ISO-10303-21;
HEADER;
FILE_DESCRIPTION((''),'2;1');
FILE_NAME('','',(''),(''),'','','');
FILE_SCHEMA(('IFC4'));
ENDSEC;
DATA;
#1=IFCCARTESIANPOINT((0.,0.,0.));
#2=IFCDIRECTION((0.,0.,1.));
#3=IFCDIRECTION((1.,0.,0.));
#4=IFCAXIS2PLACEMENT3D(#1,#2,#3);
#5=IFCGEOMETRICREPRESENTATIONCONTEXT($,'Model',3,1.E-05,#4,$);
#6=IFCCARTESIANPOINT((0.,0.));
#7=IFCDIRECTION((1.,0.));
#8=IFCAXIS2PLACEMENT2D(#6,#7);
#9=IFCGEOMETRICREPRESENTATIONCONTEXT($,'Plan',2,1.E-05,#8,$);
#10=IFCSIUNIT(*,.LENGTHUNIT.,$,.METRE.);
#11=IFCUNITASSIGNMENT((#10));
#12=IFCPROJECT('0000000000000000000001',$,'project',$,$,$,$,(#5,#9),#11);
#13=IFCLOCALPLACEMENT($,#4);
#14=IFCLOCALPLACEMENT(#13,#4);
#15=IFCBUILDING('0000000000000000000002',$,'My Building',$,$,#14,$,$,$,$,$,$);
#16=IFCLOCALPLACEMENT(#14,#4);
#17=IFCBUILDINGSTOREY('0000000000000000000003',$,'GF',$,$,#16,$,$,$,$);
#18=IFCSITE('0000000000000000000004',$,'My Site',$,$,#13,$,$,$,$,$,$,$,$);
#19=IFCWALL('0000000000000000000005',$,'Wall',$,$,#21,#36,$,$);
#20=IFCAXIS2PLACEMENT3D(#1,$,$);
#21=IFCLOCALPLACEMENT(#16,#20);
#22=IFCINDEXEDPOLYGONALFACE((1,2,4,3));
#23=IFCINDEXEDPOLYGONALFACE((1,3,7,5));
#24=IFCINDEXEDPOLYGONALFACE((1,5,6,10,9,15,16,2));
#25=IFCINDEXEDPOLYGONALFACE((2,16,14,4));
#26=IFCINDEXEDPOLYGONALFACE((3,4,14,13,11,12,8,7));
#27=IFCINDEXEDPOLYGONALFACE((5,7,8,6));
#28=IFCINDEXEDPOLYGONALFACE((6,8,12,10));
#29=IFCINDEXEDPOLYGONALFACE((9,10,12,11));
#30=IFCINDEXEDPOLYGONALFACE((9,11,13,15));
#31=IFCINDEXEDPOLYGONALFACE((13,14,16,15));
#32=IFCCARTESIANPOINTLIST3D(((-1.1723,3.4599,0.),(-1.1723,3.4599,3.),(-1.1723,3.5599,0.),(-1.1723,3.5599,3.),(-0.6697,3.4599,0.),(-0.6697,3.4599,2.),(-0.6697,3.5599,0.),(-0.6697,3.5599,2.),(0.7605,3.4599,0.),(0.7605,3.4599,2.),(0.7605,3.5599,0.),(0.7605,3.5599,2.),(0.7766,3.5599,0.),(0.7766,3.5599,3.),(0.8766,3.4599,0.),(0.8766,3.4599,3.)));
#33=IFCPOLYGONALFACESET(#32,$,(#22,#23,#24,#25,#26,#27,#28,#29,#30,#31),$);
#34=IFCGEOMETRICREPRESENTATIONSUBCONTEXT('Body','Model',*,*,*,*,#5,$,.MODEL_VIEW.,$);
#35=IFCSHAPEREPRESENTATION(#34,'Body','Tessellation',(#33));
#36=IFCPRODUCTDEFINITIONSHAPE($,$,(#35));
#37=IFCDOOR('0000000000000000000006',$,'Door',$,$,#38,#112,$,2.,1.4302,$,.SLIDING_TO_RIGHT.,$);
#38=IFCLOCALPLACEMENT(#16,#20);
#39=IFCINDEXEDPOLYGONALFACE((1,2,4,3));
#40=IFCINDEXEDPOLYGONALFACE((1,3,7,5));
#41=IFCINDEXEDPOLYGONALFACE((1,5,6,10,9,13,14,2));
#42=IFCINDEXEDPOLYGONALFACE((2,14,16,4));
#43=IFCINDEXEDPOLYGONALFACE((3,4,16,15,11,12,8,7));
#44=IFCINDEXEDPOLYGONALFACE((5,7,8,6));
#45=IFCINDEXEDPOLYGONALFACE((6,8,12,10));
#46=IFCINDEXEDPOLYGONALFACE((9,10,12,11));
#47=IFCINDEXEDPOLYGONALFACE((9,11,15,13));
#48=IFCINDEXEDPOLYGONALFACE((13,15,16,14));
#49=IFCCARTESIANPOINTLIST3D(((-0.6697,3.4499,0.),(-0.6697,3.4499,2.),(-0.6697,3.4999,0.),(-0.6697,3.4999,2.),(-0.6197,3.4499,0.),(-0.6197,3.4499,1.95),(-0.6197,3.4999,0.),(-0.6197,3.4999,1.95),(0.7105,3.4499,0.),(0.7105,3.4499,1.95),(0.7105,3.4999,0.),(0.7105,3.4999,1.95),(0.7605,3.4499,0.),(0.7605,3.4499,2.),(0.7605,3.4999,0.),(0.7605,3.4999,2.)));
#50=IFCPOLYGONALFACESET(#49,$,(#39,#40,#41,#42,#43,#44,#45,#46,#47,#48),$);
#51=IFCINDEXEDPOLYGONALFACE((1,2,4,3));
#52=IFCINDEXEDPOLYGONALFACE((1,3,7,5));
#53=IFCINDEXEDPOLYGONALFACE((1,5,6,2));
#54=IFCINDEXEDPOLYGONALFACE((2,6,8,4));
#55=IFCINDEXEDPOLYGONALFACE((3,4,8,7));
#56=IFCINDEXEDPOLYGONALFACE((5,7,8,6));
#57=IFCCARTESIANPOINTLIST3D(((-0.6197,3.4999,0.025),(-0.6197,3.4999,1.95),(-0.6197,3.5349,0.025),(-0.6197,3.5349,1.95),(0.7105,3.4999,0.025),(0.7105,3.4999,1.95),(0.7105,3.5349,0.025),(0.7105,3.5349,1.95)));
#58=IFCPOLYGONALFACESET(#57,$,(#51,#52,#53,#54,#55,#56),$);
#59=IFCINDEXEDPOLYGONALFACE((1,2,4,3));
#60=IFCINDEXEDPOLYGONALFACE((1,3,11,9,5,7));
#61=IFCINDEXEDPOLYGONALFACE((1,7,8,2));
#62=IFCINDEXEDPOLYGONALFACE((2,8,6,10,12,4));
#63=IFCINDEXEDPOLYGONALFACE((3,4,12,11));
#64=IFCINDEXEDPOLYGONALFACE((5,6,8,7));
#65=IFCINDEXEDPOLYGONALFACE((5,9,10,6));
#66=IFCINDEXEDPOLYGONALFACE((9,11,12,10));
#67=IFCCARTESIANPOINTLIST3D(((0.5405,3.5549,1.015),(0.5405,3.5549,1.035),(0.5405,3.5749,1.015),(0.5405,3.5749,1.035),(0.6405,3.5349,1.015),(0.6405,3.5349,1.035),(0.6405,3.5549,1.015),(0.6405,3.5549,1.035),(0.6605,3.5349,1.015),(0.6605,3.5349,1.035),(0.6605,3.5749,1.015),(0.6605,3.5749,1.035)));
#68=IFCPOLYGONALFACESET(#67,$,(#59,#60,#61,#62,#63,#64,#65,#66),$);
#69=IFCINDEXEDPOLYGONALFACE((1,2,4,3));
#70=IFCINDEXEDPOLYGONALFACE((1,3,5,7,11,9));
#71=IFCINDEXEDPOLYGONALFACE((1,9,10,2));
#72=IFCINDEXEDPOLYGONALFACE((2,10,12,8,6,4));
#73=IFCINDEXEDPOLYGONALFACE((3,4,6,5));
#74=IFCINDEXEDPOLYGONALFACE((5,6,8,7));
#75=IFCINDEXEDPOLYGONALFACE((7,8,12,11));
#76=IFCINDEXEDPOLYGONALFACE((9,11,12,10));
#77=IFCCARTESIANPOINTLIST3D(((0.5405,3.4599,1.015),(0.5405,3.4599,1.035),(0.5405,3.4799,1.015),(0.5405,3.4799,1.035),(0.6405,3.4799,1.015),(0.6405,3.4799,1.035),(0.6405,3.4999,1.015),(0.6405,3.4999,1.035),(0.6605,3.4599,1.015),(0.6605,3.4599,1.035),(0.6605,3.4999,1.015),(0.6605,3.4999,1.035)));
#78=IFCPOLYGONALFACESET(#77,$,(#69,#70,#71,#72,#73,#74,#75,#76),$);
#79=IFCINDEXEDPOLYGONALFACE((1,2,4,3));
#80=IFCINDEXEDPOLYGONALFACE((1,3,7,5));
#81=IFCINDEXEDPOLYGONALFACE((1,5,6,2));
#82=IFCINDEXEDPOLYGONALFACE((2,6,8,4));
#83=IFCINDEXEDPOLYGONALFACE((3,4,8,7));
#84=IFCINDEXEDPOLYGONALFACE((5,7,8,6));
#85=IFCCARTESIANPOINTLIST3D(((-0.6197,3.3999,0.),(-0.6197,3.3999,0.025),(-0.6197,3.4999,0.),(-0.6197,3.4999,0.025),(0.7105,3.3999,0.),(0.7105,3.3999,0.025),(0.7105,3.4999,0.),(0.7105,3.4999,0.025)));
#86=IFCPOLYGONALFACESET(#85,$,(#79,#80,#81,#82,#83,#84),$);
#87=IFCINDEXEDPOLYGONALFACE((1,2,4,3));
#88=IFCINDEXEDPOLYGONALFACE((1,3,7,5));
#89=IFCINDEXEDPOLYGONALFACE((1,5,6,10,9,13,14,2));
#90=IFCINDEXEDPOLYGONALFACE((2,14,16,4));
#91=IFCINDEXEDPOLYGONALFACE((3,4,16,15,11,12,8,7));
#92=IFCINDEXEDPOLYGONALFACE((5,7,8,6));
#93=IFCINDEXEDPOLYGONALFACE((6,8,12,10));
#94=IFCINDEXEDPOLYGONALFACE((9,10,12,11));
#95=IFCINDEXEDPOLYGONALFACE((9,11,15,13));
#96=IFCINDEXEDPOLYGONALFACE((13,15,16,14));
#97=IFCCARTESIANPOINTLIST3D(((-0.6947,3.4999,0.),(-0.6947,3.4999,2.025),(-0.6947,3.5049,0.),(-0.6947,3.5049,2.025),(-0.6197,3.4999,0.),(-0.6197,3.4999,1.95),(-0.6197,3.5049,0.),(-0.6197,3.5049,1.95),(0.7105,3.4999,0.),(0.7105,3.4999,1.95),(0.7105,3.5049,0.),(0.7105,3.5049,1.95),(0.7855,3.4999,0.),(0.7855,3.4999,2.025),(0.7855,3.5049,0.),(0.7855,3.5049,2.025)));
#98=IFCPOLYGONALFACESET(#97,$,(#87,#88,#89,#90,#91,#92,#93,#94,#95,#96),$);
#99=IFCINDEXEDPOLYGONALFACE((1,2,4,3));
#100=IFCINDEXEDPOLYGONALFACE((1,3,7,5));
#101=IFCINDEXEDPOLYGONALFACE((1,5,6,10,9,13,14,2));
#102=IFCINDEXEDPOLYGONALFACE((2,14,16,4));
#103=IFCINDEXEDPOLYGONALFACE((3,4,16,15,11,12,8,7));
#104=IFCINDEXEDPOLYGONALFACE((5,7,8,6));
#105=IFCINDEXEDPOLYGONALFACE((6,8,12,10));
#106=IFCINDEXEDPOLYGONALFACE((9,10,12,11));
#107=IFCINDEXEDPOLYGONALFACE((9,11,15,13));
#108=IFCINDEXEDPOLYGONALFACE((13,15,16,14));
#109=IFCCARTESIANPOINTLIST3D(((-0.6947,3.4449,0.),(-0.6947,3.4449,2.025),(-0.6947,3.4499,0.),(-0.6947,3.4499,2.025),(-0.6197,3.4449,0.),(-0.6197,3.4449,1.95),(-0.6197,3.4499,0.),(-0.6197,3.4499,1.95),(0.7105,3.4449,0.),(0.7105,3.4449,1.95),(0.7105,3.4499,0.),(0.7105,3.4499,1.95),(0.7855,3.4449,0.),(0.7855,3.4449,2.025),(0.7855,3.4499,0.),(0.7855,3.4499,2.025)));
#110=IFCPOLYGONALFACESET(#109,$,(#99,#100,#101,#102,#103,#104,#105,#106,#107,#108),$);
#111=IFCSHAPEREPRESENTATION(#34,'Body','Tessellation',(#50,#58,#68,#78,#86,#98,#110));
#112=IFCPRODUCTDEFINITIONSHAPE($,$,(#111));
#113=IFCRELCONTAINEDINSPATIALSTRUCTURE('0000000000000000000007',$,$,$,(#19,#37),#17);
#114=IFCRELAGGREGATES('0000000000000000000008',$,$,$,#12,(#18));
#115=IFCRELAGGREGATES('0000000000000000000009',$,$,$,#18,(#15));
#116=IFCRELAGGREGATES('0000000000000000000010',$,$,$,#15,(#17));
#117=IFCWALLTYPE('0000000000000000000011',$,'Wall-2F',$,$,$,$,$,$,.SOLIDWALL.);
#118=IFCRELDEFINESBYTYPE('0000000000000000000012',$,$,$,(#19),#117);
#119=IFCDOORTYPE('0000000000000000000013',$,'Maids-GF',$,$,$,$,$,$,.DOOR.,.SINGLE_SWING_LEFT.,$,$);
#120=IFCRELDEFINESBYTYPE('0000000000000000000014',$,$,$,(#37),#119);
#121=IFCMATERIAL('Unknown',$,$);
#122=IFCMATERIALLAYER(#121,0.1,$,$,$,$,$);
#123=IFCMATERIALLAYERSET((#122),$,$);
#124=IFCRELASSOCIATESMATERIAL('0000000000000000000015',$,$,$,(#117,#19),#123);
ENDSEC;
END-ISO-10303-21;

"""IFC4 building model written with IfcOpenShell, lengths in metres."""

from ifc_helpers import new_model, entity, si_unit, frame, origin_with_axes, origin_2d_with_axis, place, context, subcontext, project, spatial, line, indexed_curve, outline, extrude, shape, source, transform, mapped, material, layer, layer_set, layer_usage, type_object, type_shapes, element, fill, save


model = new_model("IFC4")

# Units and contexts
model_context = context("Model", 3, precision=1e-05, world=origin_with_axes())
plan_context = context("Plan", 2, precision=1e-05, world=origin_2d_with_axis())
body_context_1 = subcontext(model_context, "Body", "Model", "MODEL_VIEW")
body_context_2 = subcontext(plan_context, "Body", "Plan", "PLAN_VIEW")
ifc_project = project(units=[si_unit("LENGTHUNIT", "METRE")], contexts=[model_context, plan_context])

# Site, building, storey
site_placement = place(None, origin_with_axes())
site = spatial("IfcSite", under=ifc_project, at=site_placement, Name="My Site")
building_placement = place(site_placement, origin_with_axes())
building = spatial("IfcBuilding", under=site, at=building_placement, Name="My Building")
storey_placement = place(building_placement, origin_with_axes())
storey = spatial("IfcBuildingStorey", under=building, at=storey_placement, Name="GF")

# Shared definitions
ifc_material_1 = material(Name="Unknown")

# Shared definitions
ifc_layer_1 = layer(ifc_material_1, 0.1)
ifc_layer_set_1 = layer_set([ifc_layer_1])
wall_type = type_object("IfcWallType", Name="Wall-2F", PredefinedType="SOLIDWALL", material=ifc_layer_set_1)

# Wall, opening, door
ifc_layer_usage_1 = layer_usage(ifc_layer_set_1, "AXIS2", "POSITIVE", 0.0)
wall_1_placement = place(storey_placement, frame((0.7766, 3.5599, 0.0), z_axis=(0.0, 0.0, 1.0), x_axis=(-1.0, 0.0, 0.0)))
wall_1 = element("IfcWall", 1, at=wall_1_placement, inside=storey, type_object=wall_type, material=ifc_layer_usage_1, Name="Wall", context=body_context_1, shape_type="SweptSolid", body=[
    extrude(outline(indexed_curve([(0.0, 0.0), (-0.1, 0.1), (1.9489, 0.1), (1.9489, 0.0)], segments=[line(1, 2, 3, 4, 1)])), origin_with_axes(), (0.0, 0.0, 1.0), 3.0),
])
shared_shape_1 = source(origin_with_axes(), body_context_1, "Body", "SweptSolid", [
    extrude(outline(indexed_curve([(0.0, 0.0), (1.4302, 0.0), (1.4302, 2.0), (0.0, 2.0)], segments=[line(1, 2, 3, 4, 1)])), frame((0.0, -0.6, 0.0), z_axis=(0.0, -1.0, 0.0), x_axis=(1.0, 0.0, 0.0)), (0.0, 0.0, -1.0), 1.2),
])
opening_1_placement = place(wall_1_placement, frame((0.0161, 0.06, 0.0), z_axis=(0.0, 0.0, 1.0), x_axis=(1.0, -0.000002, 0.0)))
opening_1 = element("IfcOpeningElement", 2, at=opening_1_placement, cuts=wall_1, PredefinedType="OPENING", context=body_context_1, shape_type="MappedRepresentation", body=[
    mapped(shared_shape_1, transform((0.0, 0.0, 0.0), x_axis=(1.0, 0.0, 0.0), y_axis=(0.0, 1.0, 0.0), z_axis=(0.0, 0.0, 1.0), scale=1.0)),
])
door_type_1 = type_object("IfcDoorType", Name="Maids-GF", OperationType="SINGLE_SWING_LEFT", PredefinedType="DOOR")
shared_shape_2 = source(origin_with_axes(), body_context_1, "Body", "SweptSolid", [
    extrude(outline(indexed_curve([(0.0, 0.0), (0.0, 2.0), (1.4302, 2.0), (1.4302, 0.0), (1.3802, 0.0), (1.3802, 1.95), (0.05, 1.95), (0.05, 0.0)], segments=[line(1, 2, 3, 4, 5, 6, 7, 8, 1)])), frame((0.0, 0.0, 0.0), z_axis=(0.0, -1.0, 0.0), x_axis=(1.0, 0.0, 0.0)), (0.0, 0.0, -1.0), 0.05),
    extrude(outline(indexed_curve([(0.0, 0.0), (1.3302, 0.0), (1.3302, 0.035), (0.0, 0.035)], segments=[line(1, 2, 3, 4, 1)])), frame((0.05, -0.035, 0.025), z_axis=(0.0, 0.0, 1.0), x_axis=(1.0, 0.0, 0.0)), (0.0, 0.0, 1.0), 1.925),
    extrude(outline(indexed_curve([(0.0, 0.0), (0.0, -0.04), (0.12, -0.04), (0.12, -0.02), (0.02, -0.02), (0.02, 0.0)], segments=[line(1, 2, 3, 4, 5, 6, 1)])), frame((0.1, -0.035, 1.015), z_axis=(0.0, 0.0, 1.0), x_axis=(1.0, 0.0, 0.0)), (0.0, 0.0, 1.0), 0.02),
    extrude(outline(indexed_curve([(0.0, 0.0), (0.0, 0.04), (0.12, 0.04), (0.12, 0.02), (0.02, 0.02), (0.02, 0.0)], segments=[line(1, 2, 3, 4, 5, 6, 1)])), frame((0.1, 0.0, 1.015), z_axis=(0.0, 0.0, 1.0), x_axis=(1.0, 0.0, 0.0)), (0.0, 0.0, 1.0), 0.02),
    extrude(outline(indexed_curve([(0.0, 0.0), (1.3302, 0.0), (1.3302, 0.1), (0.0, 0.1)], segments=[line(1, 2, 3, 4, 1)])), frame((0.05, 0.0, 0.0), z_axis=(0.0, 0.0, 1.0), x_axis=(1.0, 0.0, 0.0)), (0.0, 0.0, 1.0), 0.025),
    extrude(outline(indexed_curve([(0.0, 0.0), (0.0, 2.025), (1.4802, 2.025), (1.4802, 0.0), (1.4052, 0.0), (1.4052, 1.95), (0.075, 1.95), (0.075, 0.0)], segments=[line(1, 2, 3, 4, 5, 6, 7, 8, 1)])), frame((-0.025, -0.005, 0.0), z_axis=(0.0, -1.0, 0.0), x_axis=(1.0, 0.0, 0.0)), (0.0, 0.0, -1.0), 0.005),
    extrude(outline(indexed_curve([(0.0, 0.0), (0.0, 2.025), (1.4802, 2.025), (1.4802, 0.0), (1.4052, 0.0), (1.4052, 1.95), (0.075, 1.95), (0.075, 0.0)], segments=[line(1, 2, 3, 4, 5, 6, 7, 8, 1)])), frame((-0.025, 0.05, 0.0), z_axis=(0.0, -1.0, 0.0), x_axis=(1.0, 0.0, 0.0)), (0.0, 0.0, -1.0), 0.005),
])
shared_shape_3 = source(origin_with_axes(), body_context_2, "Body", "Curve2D", [
    entity("IfcIndexedPolyCurve", entity("IfcCartesianPointList2D", [[0.0, 0.0], [0.05, 0.0], [0.05, 0.05], [0.0, 0.05]]), [entity("IfcLineIndex", [1, 2, 3, 4, 1])]),
    entity("IfcIndexedPolyCurve", entity("IfcCartesianPointList2D", [[1.4302, 0.0], [1.3802, 0.0], [1.3802, 0.05], [1.4302, 0.05]]), [entity("IfcLineIndex", [1, 2, 3, 4, 1])]),
    entity("IfcIndexedPolyCurve", entity("IfcCartesianPointList2D", [[2.0454, -0.035], [0.7151, -0.035], [0.7151, 0.0], [2.0454, 0.0]]), [entity("IfcLineIndex", [1, 2, 3, 4, 1])]),
])
type_shapes(door_type_1, [shared_shape_2, shared_shape_3])
door_1_placement = place(opening_1_placement, frame((0.0, 0.0, 0.0), z_axis=(0.0, 0.0, 1.0), x_axis=(1.0, 0.0, 0.0)))
door_1 = element("IfcDoor", 3, at=door_1_placement, inside=storey, type_object=door_type_1, Name="Door", OperationType="SLIDING_TO_RIGHT", OverallHeight=2.0, OverallWidth=1.4302, shapes=[
    shape(body_context_1, "Body", "MappedRepresentation", [mapped(shared_shape_2, transform((0.0, 0.0, 0.0), x_axis=(1.0, 0.0, 0.0), y_axis=(0.0, 1.0, 0.0), z_axis=(0.0, 0.0, 1.0), scale=1.0))]),
    shape(body_context_2, "Body", "MappedRepresentation", [mapped(shared_shape_3, transform((0.0, 0.0, 0.0), x_axis=(1.0, 0.0, 0.0), y_axis=(0.0, 1.0, 0.0), z_axis=(0.0, 0.0, 1.0), scale=1.0))]),
])
fill(opening_1, door_1)

save(model, "model.ifc")
